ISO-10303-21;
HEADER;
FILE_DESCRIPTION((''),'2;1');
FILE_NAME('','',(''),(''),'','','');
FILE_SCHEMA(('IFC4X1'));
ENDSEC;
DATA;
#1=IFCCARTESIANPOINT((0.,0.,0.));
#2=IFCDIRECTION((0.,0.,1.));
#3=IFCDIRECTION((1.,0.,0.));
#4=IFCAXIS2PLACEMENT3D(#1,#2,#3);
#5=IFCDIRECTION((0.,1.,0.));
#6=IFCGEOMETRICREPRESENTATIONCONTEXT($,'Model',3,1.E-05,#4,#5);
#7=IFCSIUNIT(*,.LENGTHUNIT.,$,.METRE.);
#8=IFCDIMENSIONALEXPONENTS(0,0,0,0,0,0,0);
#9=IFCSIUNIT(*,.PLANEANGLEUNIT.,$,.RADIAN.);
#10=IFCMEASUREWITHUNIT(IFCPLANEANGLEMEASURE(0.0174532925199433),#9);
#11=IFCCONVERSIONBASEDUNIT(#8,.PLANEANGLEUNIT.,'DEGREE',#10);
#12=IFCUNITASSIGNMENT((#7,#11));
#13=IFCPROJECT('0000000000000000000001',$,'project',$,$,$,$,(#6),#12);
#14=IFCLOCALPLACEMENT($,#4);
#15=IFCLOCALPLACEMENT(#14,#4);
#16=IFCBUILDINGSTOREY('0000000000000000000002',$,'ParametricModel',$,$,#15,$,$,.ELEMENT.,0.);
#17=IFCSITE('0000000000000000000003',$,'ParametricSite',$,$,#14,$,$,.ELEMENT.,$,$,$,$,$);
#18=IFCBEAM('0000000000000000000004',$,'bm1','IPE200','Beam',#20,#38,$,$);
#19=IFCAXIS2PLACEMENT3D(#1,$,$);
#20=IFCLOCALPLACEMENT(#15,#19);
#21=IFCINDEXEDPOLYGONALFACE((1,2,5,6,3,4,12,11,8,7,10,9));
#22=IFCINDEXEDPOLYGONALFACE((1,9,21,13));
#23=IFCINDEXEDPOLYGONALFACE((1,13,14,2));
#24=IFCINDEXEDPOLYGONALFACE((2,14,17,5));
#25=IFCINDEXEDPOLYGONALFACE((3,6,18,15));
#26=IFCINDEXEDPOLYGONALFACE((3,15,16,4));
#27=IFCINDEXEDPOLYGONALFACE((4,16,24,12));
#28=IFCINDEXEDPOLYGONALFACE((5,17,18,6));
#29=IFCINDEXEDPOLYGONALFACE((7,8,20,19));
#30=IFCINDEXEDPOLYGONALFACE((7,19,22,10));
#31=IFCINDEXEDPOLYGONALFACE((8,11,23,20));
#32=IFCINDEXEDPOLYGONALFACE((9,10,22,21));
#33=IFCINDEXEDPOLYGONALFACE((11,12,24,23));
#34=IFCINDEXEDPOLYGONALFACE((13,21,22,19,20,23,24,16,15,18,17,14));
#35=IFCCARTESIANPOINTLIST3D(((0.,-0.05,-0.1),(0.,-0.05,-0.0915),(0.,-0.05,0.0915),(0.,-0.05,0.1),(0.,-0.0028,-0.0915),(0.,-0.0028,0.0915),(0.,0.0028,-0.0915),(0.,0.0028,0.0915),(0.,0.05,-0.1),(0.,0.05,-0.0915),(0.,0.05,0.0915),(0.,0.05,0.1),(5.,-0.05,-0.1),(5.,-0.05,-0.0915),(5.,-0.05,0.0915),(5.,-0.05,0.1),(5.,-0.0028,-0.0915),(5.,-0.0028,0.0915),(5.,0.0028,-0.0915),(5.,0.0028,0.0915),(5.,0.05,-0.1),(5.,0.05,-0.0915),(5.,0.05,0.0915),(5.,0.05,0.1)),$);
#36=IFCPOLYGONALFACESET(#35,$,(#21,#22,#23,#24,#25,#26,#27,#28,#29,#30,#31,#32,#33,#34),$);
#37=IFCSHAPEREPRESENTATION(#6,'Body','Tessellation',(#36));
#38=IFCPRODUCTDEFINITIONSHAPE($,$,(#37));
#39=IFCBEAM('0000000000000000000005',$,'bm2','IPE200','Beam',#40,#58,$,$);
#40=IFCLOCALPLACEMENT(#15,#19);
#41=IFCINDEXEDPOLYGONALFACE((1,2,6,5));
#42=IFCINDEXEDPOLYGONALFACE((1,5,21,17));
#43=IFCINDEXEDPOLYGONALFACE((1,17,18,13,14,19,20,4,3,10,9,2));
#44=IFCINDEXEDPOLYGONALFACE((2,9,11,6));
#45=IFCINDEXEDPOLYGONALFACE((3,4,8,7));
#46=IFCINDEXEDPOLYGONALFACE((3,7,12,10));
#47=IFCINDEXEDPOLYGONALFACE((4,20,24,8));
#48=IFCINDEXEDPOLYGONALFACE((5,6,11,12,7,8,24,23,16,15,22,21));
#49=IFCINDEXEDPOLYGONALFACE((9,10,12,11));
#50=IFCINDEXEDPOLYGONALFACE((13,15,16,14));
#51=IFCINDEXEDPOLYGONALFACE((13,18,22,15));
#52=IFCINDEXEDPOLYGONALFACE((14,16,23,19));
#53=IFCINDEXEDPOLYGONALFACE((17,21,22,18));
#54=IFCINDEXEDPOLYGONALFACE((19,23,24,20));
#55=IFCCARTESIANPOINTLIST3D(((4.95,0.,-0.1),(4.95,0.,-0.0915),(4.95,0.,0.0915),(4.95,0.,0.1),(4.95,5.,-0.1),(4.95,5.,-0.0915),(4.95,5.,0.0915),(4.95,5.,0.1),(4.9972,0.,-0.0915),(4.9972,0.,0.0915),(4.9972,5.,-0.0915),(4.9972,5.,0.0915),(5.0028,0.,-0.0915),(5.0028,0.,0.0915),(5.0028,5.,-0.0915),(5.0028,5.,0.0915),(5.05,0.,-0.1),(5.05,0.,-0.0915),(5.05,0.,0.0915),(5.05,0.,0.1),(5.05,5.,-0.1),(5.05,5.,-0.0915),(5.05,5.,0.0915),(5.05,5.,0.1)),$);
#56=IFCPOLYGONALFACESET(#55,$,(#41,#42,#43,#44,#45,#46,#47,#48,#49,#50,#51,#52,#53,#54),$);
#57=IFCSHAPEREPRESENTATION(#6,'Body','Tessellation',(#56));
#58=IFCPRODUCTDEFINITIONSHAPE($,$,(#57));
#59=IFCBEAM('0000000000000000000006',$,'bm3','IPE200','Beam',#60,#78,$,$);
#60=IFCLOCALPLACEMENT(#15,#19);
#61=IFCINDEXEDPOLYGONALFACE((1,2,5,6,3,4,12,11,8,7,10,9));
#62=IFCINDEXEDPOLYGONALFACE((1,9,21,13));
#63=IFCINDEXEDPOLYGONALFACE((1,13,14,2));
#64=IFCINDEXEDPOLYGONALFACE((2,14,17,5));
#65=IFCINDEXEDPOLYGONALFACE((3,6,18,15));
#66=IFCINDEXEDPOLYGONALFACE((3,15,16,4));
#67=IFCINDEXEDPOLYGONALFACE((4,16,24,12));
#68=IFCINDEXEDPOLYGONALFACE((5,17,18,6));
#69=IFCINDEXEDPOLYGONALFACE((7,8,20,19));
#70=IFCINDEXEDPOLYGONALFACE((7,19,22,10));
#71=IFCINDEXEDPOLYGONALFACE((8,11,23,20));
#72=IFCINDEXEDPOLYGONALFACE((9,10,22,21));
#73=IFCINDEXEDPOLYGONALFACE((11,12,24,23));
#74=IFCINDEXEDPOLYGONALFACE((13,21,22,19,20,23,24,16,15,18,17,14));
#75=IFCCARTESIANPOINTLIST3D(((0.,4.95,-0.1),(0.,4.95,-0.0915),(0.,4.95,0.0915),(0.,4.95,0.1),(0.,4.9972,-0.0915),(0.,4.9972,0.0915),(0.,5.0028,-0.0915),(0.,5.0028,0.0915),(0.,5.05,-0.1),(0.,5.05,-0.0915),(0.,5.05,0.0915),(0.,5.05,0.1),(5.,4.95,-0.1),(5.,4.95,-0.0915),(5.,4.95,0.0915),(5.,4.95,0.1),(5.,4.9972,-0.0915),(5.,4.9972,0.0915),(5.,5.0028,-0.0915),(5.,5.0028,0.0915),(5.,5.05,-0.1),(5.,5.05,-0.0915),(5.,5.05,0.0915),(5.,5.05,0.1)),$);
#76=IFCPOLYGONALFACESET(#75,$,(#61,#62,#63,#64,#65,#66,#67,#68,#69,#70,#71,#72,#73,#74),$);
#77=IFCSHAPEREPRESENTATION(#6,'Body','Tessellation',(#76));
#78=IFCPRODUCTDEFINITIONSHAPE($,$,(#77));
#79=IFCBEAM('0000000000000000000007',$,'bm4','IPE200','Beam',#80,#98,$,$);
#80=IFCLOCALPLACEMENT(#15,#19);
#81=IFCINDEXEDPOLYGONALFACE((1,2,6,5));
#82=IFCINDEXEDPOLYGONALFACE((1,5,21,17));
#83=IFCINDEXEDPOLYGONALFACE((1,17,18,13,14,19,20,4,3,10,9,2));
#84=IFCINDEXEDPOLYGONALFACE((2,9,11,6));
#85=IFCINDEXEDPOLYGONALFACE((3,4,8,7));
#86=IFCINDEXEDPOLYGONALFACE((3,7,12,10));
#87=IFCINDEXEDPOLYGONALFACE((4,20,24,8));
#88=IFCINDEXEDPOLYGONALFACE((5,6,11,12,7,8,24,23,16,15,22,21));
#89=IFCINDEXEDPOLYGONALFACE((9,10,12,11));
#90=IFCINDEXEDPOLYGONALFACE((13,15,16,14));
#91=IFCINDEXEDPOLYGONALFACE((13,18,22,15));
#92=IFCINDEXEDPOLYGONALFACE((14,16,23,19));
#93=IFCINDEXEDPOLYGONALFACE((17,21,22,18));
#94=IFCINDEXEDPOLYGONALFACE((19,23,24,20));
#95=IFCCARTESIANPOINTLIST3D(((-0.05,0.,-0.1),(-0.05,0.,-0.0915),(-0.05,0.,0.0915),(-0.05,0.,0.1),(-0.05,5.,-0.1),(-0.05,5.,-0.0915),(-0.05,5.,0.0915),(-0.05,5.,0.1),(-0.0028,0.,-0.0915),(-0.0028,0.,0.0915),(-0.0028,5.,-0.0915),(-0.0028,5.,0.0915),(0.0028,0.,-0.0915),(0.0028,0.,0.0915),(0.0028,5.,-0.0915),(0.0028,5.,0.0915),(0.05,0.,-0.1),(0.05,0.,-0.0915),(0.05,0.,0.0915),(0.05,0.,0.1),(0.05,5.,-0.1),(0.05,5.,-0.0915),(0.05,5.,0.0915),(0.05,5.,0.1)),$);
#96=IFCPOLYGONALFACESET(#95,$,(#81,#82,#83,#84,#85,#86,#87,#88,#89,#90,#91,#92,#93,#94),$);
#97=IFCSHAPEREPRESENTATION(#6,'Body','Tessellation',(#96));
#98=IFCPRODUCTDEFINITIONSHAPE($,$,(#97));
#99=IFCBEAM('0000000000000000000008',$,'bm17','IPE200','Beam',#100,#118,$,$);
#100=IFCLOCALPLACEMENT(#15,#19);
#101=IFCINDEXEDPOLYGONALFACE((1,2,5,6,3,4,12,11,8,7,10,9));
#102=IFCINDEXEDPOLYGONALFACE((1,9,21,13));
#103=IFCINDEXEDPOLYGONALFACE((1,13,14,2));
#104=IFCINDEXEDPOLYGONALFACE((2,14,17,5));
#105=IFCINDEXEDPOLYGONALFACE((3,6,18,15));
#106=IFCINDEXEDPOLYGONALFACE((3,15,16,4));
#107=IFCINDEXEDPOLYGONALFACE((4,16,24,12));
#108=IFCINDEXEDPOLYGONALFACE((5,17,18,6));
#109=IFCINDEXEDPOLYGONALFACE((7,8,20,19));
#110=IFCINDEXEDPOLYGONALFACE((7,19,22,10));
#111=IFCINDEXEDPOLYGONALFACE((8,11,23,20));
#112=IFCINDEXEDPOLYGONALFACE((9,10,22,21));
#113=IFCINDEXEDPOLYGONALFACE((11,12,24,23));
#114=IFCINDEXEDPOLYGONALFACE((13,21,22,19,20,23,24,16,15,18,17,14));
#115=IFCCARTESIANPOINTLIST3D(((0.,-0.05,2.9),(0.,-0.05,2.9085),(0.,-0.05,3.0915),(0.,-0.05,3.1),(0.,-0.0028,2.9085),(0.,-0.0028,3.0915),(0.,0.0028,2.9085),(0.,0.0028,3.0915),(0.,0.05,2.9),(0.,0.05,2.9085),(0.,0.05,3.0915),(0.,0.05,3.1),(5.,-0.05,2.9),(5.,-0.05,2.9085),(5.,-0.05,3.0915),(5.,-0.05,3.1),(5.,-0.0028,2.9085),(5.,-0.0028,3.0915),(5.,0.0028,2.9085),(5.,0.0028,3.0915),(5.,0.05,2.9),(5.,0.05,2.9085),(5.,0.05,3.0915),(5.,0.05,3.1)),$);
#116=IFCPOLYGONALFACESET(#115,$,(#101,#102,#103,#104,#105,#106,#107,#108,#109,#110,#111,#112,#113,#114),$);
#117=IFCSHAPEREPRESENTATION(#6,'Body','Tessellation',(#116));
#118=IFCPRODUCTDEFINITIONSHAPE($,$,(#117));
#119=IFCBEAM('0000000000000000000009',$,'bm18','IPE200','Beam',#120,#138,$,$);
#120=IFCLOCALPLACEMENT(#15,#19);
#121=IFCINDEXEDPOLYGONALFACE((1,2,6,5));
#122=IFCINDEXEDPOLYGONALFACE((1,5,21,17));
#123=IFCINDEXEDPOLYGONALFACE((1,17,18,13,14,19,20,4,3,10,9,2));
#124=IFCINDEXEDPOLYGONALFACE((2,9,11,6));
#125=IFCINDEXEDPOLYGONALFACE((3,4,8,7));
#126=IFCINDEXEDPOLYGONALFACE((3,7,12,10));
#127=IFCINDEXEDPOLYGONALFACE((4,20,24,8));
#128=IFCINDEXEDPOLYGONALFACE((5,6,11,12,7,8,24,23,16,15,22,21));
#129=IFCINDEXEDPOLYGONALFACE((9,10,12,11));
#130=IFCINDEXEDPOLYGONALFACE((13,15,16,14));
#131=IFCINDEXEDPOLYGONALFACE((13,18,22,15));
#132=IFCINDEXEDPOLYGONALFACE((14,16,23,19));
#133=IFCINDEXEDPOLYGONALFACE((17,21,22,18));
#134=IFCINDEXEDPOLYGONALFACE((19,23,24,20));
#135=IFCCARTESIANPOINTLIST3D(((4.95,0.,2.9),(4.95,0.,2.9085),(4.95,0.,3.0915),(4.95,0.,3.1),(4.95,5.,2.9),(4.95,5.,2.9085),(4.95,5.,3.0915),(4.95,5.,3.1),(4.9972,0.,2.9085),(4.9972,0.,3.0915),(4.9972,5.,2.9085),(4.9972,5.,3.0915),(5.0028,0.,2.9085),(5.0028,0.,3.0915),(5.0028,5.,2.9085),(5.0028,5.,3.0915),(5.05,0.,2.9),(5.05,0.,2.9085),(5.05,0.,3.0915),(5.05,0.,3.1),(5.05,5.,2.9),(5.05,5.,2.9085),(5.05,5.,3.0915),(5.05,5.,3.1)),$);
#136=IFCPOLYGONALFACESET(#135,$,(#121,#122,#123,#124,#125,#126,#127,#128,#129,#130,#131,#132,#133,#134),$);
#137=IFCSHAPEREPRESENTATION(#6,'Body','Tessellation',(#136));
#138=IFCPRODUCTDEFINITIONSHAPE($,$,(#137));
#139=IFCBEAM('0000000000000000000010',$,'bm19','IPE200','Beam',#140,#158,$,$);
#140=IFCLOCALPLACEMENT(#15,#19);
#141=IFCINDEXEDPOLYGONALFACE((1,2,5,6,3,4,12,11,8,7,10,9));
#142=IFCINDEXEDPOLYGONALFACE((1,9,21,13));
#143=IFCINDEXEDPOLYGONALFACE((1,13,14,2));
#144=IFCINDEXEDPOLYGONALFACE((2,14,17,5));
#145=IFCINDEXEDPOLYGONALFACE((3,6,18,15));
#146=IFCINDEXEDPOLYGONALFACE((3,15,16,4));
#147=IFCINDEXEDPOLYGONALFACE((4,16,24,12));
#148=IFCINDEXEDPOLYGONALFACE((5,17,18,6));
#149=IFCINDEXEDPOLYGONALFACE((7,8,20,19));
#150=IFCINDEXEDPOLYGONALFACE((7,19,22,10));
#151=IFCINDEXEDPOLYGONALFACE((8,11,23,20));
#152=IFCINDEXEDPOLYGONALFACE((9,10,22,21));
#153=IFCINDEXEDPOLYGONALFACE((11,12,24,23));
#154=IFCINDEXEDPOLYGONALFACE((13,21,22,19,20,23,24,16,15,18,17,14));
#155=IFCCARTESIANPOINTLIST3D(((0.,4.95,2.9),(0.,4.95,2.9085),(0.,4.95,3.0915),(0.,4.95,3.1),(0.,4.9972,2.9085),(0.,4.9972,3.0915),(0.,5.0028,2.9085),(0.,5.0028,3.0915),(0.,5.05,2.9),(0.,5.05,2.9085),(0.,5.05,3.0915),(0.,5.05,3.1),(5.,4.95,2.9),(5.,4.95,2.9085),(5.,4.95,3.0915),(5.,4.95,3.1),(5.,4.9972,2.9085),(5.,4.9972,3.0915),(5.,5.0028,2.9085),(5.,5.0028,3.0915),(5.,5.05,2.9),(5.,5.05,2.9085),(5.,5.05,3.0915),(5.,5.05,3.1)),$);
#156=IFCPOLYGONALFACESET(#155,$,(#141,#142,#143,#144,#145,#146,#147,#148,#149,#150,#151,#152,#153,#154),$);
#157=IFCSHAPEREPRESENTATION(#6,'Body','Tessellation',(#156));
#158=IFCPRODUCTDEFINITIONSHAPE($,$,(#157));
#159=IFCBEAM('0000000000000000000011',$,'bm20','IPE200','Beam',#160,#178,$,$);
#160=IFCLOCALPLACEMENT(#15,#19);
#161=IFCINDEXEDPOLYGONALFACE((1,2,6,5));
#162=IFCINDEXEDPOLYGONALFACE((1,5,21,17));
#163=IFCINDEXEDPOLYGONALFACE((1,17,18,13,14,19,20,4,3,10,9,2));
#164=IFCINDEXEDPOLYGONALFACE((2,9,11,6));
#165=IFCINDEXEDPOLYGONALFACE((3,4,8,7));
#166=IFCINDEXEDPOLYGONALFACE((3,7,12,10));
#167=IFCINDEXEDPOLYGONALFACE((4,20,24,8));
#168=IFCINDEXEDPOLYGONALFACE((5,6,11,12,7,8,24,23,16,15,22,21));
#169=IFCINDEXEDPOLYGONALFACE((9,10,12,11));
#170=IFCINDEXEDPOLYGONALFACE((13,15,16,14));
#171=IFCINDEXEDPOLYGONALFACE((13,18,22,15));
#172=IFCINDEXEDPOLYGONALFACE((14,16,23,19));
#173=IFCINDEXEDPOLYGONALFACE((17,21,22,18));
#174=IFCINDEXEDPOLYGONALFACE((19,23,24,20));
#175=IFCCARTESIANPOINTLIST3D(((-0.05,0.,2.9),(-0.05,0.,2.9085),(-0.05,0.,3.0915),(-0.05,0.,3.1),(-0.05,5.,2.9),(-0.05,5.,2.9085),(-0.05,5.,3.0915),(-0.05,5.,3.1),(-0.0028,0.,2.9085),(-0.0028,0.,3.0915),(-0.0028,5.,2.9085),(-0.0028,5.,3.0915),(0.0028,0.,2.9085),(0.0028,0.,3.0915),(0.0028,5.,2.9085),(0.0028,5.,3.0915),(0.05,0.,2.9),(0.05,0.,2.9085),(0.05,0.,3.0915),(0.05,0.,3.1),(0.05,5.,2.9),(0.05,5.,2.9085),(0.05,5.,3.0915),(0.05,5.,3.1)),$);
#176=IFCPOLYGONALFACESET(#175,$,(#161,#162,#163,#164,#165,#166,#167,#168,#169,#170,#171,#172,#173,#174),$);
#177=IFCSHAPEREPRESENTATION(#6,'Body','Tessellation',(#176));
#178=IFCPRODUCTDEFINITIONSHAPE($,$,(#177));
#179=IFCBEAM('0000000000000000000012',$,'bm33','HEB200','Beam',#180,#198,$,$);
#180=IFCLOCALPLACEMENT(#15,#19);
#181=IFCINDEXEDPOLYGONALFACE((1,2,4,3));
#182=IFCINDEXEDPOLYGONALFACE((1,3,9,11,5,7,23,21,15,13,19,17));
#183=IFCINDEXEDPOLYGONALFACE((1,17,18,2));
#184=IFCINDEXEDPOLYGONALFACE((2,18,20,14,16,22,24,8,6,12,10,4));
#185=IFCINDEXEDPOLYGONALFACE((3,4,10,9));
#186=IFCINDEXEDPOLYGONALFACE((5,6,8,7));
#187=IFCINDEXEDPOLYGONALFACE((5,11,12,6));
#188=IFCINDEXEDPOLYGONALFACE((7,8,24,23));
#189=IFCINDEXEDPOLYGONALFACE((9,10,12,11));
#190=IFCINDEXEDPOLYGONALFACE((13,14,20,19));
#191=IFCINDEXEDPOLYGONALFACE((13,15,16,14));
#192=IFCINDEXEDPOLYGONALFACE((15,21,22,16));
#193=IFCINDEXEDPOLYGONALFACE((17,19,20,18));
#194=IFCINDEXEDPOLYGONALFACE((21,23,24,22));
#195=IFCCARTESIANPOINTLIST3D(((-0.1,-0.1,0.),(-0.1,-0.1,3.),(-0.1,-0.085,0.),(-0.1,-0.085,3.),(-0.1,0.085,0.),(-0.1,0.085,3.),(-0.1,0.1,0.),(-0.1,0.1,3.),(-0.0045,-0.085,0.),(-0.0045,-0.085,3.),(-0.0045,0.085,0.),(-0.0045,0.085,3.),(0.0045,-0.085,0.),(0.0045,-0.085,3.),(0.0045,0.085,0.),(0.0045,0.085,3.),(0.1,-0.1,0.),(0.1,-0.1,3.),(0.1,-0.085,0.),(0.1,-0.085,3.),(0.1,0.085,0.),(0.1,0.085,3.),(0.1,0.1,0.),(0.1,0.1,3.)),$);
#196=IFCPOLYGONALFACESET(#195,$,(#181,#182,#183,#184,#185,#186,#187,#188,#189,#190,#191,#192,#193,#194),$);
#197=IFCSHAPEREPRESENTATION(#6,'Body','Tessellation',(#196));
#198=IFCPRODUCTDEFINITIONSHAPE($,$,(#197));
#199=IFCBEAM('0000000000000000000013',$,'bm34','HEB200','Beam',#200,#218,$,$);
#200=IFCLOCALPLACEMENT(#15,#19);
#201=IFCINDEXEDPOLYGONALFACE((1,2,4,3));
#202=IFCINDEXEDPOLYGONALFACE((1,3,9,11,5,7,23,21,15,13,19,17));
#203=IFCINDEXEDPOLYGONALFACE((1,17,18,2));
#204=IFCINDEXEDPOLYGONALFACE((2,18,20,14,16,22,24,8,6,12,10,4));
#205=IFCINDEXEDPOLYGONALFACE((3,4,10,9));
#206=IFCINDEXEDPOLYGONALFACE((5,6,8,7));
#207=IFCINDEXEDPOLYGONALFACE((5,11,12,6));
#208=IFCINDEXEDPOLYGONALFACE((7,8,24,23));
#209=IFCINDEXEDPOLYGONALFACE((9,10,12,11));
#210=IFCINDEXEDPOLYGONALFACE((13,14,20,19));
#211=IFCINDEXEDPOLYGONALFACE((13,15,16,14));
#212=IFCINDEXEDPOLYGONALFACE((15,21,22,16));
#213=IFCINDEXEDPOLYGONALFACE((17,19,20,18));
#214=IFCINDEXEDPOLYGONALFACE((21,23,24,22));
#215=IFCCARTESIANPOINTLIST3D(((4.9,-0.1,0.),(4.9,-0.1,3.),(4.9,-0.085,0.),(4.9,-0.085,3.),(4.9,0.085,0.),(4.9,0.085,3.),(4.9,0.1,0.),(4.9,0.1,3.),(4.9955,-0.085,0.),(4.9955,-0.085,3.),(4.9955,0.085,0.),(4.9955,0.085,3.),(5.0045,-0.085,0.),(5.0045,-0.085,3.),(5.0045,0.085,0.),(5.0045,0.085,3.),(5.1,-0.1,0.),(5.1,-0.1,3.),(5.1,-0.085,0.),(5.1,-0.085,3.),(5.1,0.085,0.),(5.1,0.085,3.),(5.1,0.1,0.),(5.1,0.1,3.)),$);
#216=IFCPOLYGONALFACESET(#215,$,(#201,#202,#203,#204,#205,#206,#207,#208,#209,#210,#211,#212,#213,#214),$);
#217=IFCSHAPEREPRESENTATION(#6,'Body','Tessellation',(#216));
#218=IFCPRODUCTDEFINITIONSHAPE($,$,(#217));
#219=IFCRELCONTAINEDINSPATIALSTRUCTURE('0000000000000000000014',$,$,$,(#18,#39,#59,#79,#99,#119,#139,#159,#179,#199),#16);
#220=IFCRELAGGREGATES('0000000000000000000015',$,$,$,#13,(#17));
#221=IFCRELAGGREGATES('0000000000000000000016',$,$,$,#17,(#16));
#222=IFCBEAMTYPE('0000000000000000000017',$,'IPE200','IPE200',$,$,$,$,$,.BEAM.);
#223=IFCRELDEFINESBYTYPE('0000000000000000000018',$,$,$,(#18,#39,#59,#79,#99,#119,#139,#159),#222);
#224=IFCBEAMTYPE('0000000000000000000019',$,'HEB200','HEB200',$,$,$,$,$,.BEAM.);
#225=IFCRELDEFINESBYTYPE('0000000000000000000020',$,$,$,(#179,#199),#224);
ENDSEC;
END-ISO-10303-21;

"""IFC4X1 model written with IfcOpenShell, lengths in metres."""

from ifc_helpers import new_model, entity, si_unit, converted_unit, direction, frame, origin, origin_with_axes, place, context, project, spatial, i_section, extrude, type_object, element, save


model = new_model("IFC4X1")

# Units and contexts
model_context = context("Model", 3, precision=1e-05, world=origin_with_axes(), true_north=direction((0.0, 1.0, 0.0)))
ifc_project = project(units=[si_unit("LENGTHUNIT", "METRE"), converted_unit("PLANEANGLEUNIT", "DEGREE", entity("IfcPlaneAngleMeasure", 0.0174532925199433), si_unit("PLANEANGLEUNIT", "RADIAN"), dimensions=[0, 0, 0, 0, 0, 0, 0])], contexts=[model_context])

# Site, storey
site_placement = place(None, origin_with_axes())
site = spatial("IfcSite", under=ifc_project, at=site_placement, Name="ParametricSite", CompositionType="ELEMENT")
storey_placement = place(site_placement, origin_with_axes())
storey = spatial("IfcBuildingStorey", under=site, at=storey_placement, Name="ParametricModel", CompositionType="ELEMENT", Elevation=0.0)

# Beams
beam_type_1 = type_object("IfcBeamType", Name="IPE200", Description="IPE200", PredefinedType="BEAM")
placement = place(storey_placement, origin_with_axes())
for number, where, z_axis, x_axis, name in (
    (1, (0.0, 0.0, 0.0), (1.0, 0.0, 0.0), (0.0, 1.0, 0.0), "bm1"),
    (2, (5.0, 0.0, 0.0), (0.0, 1.0, 0.0), (-1.0, 0.0, 0.0), "bm2"),
    (3, (5.0, 5.0, 0.0), (-1.0, 0.0, 0.0), (0.0, -1.0, 0.0), "bm3"),
    (4, (0.0, 5.0, 0.0), (0.0, -1.0, 0.0), (1.0, 0.0, 0.0), "bm4"),
    (5, (0.0, 0.0, 3.0), (1.0, 0.0, 0.0), (0.0, 1.0, 0.0), "bm17"),
    (6, (5.0, 0.0, 3.0), (0.0, 1.0, 0.0), (-1.0, 0.0, 0.0), "bm18"),
    (7, (5.0, 5.0, 3.0), (-1.0, 0.0, 0.0), (0.0, -1.0, 0.0), "bm19"),
    (8, (0.0, 5.0, 3.0), (0.0, -1.0, 0.0), (1.0, 0.0, 0.0), "bm20"),
):
    element("IfcBeam", number, at=place(placement, frame(where, z_axis=z_axis, x_axis=x_axis)), inside=storey, type_object=beam_type_1, Name=name, Description="IPE200", ObjectType="Beam", context=model_context, shape_type="SweptSolid", body=[
        extrude(i_section(OverallWidth=0.1, OverallDepth=0.2, WebThickness=0.0056, FlangeThickness=0.0085), origin(), (0.0, 0.0, 1.0), 5.0),
    ])
beam_type_2 = type_object("IfcBeamType", Name="HEB200", Description="HEB200", PredefinedType="BEAM")
beam_placement = place(placement, origin_with_axes())
element("IfcBeam", 9, at=beam_placement, inside=storey, type_object=beam_type_2, Name="bm33", Description="HEB200", ObjectType="Beam", context=model_context, shape_type="SweptSolid", body=[
    extrude(i_section(OverallWidth=0.2, OverallDepth=0.2, WebThickness=0.009, FlangeThickness=0.015), origin(), (0.0, 0.0, 1.0), 3.0),
])
for number, where, z_axis, x_axis, name in (
    (10, (5.0, 0.0, 0.0), (0.0, 0.0, 1.0), (1.0, 0.0, 0.0), "bm34"),
):
    element("IfcBeam", number, at=place(placement, frame(where, z_axis=z_axis, x_axis=x_axis)), inside=storey, type_object=beam_type_2, Name=name, Description="HEB200", ObjectType="Beam", context=model_context, shape_type="SweptSolid", body=[
        extrude(i_section(OverallWidth=0.2, OverallDepth=0.2, WebThickness=0.009, FlangeThickness=0.015), origin(), (0.0, 0.0, 1.0), 3.0),
    ])

save(model, "model.ifc")
